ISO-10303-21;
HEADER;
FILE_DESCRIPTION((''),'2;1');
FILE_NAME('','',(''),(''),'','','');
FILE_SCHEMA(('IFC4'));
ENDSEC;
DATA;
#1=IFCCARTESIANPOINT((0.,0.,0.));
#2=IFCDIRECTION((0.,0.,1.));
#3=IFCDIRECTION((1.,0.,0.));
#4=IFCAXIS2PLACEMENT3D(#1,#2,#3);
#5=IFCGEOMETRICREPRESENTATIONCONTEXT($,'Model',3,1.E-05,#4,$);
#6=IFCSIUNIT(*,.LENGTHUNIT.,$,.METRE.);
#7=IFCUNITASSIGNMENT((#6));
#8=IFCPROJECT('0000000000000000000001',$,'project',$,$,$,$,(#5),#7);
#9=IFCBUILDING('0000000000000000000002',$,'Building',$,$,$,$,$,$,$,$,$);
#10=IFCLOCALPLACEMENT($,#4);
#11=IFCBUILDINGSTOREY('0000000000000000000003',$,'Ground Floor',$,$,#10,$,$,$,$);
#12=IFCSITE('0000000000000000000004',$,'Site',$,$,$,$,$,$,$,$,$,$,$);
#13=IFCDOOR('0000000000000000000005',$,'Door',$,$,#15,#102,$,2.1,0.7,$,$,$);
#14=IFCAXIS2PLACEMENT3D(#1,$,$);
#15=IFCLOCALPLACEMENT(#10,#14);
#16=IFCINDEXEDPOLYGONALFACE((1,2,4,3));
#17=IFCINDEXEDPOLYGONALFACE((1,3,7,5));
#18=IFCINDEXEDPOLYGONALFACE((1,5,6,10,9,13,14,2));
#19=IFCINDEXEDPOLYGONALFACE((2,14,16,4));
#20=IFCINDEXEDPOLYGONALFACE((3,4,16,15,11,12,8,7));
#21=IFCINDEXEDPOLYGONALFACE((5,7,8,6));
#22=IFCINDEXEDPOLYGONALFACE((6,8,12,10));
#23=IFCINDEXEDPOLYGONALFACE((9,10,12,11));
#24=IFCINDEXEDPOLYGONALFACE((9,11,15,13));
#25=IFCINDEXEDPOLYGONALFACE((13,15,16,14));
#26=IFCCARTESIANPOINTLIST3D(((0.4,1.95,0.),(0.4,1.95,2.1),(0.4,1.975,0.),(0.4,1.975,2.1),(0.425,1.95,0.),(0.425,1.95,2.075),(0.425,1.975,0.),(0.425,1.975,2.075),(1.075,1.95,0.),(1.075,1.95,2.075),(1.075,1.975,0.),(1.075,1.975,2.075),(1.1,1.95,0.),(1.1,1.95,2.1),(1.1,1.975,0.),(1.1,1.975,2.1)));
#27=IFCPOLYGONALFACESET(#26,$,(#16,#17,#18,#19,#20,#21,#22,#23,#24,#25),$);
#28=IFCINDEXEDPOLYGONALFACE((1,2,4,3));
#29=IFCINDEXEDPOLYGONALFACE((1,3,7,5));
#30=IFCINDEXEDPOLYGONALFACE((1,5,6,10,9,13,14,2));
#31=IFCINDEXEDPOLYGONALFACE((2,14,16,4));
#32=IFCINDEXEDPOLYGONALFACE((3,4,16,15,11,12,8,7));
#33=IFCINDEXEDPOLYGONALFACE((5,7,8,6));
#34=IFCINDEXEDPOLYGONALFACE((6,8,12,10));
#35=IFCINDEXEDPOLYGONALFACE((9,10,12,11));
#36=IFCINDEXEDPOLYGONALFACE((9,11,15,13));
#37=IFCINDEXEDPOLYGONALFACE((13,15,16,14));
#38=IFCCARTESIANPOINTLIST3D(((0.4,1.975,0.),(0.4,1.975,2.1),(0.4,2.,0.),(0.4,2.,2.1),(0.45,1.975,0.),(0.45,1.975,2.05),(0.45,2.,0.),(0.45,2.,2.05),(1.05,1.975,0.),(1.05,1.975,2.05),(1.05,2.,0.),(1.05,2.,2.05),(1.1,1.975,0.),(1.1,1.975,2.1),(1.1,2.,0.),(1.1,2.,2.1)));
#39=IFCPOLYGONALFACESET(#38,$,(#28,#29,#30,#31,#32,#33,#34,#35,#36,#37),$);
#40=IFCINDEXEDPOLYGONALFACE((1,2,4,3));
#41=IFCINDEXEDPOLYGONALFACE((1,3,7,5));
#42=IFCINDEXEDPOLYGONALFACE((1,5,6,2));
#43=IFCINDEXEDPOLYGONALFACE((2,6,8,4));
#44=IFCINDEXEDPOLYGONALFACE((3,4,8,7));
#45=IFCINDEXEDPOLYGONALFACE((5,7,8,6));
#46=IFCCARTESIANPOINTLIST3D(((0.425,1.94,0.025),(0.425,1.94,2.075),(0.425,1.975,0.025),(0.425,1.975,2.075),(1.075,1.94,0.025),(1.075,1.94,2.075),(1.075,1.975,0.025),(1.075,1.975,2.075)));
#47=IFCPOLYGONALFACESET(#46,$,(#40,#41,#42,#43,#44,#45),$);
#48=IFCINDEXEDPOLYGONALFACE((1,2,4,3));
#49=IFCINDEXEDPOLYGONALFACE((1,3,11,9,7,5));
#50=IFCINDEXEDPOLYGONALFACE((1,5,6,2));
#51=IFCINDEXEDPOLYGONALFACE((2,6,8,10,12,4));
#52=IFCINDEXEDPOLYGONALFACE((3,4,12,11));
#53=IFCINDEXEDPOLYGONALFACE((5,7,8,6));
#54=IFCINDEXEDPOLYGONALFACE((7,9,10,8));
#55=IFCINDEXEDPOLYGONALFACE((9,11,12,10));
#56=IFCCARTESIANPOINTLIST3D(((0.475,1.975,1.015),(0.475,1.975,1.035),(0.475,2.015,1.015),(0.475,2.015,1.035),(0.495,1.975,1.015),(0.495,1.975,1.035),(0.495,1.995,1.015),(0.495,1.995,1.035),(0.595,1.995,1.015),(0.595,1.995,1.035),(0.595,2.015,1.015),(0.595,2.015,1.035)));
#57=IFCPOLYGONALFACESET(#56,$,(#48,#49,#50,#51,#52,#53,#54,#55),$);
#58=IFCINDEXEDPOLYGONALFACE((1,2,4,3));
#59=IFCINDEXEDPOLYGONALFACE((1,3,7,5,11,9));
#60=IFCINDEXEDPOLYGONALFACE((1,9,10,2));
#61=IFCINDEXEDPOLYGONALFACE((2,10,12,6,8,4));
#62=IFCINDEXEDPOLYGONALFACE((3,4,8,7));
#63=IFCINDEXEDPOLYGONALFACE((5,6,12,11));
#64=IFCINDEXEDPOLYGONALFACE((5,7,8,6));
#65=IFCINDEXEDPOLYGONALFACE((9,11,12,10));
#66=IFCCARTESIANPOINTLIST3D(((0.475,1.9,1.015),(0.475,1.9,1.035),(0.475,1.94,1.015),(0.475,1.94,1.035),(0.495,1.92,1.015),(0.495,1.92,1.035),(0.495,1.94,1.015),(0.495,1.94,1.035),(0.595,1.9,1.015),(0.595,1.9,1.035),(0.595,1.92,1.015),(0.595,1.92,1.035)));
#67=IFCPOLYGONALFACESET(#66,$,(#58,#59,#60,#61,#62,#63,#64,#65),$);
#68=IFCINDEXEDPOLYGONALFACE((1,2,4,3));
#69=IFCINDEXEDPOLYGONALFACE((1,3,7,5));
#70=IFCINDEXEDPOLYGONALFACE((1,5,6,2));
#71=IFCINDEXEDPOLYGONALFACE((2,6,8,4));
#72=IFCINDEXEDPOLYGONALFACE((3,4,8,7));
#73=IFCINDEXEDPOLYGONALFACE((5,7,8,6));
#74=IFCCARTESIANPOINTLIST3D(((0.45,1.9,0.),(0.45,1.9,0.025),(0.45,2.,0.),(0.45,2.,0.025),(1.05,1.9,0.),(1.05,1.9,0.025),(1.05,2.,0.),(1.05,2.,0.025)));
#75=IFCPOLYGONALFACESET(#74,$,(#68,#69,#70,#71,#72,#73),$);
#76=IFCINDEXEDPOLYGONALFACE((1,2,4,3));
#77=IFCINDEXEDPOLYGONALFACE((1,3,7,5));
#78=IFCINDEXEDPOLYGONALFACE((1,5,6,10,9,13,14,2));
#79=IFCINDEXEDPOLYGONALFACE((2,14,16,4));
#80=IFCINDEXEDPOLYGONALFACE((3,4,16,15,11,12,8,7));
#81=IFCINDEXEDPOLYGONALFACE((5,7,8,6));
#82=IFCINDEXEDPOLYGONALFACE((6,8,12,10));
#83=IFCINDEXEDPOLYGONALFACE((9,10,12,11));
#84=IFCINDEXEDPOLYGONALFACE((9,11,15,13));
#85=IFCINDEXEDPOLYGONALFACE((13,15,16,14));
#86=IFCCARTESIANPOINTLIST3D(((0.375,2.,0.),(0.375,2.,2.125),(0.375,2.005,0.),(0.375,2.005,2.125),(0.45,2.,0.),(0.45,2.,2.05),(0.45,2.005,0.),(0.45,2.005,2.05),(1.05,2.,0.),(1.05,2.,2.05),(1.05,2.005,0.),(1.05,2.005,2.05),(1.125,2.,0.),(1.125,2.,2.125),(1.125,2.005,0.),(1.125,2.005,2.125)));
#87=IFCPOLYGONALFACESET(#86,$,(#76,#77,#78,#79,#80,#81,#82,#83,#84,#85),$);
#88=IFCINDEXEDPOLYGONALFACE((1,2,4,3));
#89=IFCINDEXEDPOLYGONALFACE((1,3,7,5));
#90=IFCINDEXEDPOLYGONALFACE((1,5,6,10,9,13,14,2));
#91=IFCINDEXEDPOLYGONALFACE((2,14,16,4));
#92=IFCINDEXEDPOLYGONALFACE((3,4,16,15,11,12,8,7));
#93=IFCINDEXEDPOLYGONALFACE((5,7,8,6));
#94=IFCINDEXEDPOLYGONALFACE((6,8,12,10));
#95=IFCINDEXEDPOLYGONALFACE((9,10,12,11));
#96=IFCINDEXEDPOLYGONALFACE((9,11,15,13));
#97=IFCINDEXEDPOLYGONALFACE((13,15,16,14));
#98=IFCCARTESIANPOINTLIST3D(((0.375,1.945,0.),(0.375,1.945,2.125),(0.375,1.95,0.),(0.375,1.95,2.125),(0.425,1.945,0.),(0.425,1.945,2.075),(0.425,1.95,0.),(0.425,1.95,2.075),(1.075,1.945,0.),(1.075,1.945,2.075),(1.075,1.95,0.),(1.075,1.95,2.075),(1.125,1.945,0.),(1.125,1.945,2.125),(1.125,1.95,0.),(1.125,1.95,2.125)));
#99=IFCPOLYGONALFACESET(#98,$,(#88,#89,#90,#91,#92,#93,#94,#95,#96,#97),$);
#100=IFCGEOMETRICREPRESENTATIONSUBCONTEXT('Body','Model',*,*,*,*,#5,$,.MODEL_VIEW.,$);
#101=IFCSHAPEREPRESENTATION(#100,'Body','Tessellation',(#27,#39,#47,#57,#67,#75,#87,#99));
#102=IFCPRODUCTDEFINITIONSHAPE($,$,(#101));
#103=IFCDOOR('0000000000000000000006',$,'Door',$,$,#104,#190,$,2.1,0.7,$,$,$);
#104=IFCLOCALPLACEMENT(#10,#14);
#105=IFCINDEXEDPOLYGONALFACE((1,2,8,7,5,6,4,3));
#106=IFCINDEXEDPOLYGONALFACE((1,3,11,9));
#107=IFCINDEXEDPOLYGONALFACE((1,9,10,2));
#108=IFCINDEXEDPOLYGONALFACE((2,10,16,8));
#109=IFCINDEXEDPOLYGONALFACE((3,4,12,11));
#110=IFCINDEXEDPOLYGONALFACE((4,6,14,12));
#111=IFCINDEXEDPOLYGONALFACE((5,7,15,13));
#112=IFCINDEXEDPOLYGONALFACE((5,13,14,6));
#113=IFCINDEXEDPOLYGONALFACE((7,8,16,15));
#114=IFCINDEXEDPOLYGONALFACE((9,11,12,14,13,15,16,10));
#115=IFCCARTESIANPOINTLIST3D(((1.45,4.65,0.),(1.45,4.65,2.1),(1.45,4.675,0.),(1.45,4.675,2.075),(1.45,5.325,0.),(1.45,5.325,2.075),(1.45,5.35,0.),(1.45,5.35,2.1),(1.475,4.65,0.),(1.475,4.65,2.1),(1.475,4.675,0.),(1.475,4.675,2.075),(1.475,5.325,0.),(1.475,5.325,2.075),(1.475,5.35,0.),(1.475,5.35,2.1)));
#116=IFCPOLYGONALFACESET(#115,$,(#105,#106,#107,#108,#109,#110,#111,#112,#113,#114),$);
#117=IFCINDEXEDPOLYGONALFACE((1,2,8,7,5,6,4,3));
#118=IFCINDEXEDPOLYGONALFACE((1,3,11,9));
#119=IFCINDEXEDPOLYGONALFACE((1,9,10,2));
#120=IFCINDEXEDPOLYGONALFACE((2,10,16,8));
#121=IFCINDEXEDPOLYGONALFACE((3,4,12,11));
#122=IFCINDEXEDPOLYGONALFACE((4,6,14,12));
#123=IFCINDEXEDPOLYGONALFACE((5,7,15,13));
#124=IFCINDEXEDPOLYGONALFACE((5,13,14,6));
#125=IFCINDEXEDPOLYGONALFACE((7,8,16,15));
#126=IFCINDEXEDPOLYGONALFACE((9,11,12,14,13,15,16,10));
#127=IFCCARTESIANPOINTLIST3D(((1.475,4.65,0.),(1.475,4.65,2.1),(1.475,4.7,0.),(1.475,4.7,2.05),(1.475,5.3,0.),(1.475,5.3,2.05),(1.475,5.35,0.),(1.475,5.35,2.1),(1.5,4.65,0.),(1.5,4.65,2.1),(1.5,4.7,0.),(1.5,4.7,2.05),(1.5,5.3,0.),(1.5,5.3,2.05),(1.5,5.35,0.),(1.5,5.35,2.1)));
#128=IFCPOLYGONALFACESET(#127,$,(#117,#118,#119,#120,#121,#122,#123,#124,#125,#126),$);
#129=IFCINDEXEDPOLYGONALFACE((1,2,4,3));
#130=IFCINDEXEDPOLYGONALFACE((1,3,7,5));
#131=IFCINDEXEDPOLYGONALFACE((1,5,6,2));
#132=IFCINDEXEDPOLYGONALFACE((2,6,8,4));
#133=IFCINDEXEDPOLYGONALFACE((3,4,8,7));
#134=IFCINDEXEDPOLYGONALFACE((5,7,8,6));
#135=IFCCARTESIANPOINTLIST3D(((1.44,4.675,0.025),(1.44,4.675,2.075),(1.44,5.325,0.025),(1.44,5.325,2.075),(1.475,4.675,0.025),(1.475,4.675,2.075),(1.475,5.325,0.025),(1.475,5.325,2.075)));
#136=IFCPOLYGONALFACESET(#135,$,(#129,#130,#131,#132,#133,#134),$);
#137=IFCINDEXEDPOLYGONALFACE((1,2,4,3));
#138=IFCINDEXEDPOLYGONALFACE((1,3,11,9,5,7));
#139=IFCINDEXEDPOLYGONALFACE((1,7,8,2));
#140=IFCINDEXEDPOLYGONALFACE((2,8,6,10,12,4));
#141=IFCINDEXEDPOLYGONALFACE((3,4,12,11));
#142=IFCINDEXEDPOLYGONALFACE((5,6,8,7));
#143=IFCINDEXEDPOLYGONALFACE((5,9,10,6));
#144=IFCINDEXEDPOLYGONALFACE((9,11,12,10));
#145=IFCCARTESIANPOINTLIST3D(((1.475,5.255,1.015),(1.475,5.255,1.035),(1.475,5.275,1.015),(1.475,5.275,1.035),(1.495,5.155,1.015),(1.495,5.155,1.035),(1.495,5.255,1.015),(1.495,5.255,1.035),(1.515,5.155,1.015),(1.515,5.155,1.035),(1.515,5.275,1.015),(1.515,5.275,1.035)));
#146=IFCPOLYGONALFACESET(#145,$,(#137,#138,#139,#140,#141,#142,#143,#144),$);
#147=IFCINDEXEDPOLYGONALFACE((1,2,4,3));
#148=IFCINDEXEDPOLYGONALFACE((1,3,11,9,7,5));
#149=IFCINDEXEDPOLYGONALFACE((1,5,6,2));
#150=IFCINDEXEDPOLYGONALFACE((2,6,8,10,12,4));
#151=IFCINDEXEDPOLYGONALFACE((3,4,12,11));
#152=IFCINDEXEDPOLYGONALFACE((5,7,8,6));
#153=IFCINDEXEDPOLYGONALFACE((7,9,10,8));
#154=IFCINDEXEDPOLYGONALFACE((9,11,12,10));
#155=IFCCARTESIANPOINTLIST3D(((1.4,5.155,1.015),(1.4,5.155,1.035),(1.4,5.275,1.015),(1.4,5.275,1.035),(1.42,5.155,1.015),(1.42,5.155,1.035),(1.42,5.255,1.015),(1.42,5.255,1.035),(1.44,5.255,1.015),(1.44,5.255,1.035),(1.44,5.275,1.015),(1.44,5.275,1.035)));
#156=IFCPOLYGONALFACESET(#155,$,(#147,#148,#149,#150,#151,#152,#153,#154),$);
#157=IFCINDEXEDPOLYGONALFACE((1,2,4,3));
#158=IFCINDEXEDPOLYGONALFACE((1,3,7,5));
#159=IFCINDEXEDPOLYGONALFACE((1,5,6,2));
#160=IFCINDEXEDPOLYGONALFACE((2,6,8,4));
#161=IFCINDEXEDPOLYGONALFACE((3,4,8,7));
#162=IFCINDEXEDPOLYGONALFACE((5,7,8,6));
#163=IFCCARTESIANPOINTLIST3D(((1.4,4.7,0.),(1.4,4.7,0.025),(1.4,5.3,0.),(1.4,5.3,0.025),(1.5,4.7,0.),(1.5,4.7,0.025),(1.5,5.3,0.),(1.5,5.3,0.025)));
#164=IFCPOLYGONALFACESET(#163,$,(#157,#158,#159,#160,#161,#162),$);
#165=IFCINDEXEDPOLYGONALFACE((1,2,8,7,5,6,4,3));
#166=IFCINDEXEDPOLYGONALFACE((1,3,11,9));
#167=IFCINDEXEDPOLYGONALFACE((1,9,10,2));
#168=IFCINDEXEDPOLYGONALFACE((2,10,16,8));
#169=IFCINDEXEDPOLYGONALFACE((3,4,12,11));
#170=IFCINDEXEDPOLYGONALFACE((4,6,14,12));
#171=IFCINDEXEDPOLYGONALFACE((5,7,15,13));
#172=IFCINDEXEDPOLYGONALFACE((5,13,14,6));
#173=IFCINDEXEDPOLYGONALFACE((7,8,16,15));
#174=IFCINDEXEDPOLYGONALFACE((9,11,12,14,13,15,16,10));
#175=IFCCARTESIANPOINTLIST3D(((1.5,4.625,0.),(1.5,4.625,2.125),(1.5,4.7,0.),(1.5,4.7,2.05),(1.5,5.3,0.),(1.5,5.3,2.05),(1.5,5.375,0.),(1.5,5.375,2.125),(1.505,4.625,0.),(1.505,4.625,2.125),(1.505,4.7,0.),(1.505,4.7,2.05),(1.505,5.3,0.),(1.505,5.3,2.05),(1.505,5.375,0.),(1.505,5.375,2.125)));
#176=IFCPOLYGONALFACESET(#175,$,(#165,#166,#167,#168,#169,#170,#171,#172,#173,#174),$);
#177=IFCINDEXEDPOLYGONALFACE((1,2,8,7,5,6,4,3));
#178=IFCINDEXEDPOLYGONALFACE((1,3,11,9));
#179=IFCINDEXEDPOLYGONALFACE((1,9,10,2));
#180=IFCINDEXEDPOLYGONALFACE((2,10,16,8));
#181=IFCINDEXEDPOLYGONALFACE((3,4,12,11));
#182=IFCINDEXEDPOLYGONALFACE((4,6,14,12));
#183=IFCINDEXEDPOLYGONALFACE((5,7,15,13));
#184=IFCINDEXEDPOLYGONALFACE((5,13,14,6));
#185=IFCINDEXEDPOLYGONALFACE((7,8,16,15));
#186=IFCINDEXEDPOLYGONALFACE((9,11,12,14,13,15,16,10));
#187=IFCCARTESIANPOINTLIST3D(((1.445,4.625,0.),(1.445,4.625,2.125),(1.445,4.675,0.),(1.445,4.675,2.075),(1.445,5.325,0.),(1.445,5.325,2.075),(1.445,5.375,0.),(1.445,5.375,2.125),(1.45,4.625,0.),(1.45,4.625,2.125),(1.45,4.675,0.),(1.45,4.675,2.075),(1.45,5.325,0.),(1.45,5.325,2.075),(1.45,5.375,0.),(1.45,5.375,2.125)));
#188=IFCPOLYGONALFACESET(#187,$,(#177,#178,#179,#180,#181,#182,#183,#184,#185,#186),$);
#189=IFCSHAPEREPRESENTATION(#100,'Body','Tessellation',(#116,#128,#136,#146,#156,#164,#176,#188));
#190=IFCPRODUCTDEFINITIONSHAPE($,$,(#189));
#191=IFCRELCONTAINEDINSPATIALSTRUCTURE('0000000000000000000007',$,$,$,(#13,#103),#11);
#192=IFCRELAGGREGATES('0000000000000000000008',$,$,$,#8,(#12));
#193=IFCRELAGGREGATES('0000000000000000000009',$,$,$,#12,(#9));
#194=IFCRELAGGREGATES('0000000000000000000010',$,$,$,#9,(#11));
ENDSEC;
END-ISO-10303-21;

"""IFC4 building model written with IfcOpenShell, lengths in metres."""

from ifc_helpers import new_model, si_unit, frame, origin_with_axes, place, context, subcontext, project, spatial, line, indexed_curve, outline, extrude, element, save


model = new_model("IFC4")

# Units and contexts
model_context = context("Model", 3, precision=1e-05, world=origin_with_axes())
body_context = subcontext(model_context, "Body", "Model", "MODEL_VIEW")
ifc_project = project(units=[si_unit("LENGTHUNIT", "METRE")], contexts=[model_context])

# Site, building, storey
site = spatial("IfcSite", under=ifc_project, Name="Site")
building = spatial("IfcBuilding", under=site, Name="Building")
storey_placement = place(None, origin_with_axes())
storey = spatial("IfcBuildingStorey", under=building, at=storey_placement, Name="Ground Floor")

# Doors
door_1_placement = place(storey_placement, frame((1.1, 2.0, 0.0), z_axis=(0.0, 0.0, 1.0), x_axis=(-1.0, 0.0, 0.0)))
element("IfcDoor", 1, at=door_1_placement, inside=storey, Name="Door", OverallHeight=2.1, OverallWidth=0.7, context=body_context, shape_type="SweptSolid", body=[
    extrude(outline(indexed_curve([(0.0, 0.0), (0.0, 2.1), (0.7, 2.1), (0.7, 0.0), (0.675, 0.0), (0.675, 2.075), (0.025, 2.075), (0.025, 0.0)], segments=[line(1, 2, 3, 4, 5, 6, 7, 8, 1)])), frame((0.0, 0.025, 0.0), z_axis=(0.0, -1.0, 0.0), x_axis=(1.0, 0.0, 0.0)), (0.0, 0.0, -1.0), 0.025),
    extrude(outline(indexed_curve([(0.0, 0.0), (0.0, 2.1), (0.7, 2.1), (0.7, 0.0), (0.65, 0.0), (0.65, 2.05), (0.05, 2.05), (0.05, 0.0)], segments=[line(1, 2, 3, 4, 5, 6, 7, 8, 1)])), frame((0.0, 0.0, 0.0), z_axis=(0.0, -1.0, 0.0), x_axis=(1.0, 0.0, 0.0)), (0.0, 0.0, -1.0), 0.025),
    extrude(outline(indexed_curve([(0.0, 0.0), (0.65, 0.0), (0.65, 0.035), (0.0, 0.035)], segments=[line(1, 2, 3, 4, 1)])), frame((0.025, 0.025, 0.025), z_axis=(0.0, 0.0, 1.0), x_axis=(1.0, 0.0, 0.0)), (0.0, 0.0, 1.0), 2.05),
    extrude(outline(indexed_curve([(0.0, 0.0), (0.0, -0.04), (-0.12, -0.04), (-0.12, -0.02), (-0.02, -0.02), (-0.02, 0.0)], segments=[line(1, 2, 3, 4, 5, 6, 1)])), frame((0.625, 0.025, 1.015), z_axis=(0.0, 0.0, 1.0), x_axis=(1.0, 0.0, 0.0)), (0.0, 0.0, 1.0), 0.02),
    extrude(outline(indexed_curve([(0.0, 0.0), (0.0, 0.04), (-0.12, 0.04), (-0.12, 0.02), (-0.02, 0.02), (-0.02, 0.0)], segments=[line(1, 2, 3, 4, 5, 6, 1)])), frame((0.625, 0.06, 1.015), z_axis=(0.0, 0.0, 1.0), x_axis=(1.0, 0.0, 0.0)), (0.0, 0.0, 1.0), 0.02),
    extrude(outline(indexed_curve([(0.0, 0.0), (0.6, 0.0), (0.6, 0.1), (0.0, 0.1)], segments=[line(1, 2, 3, 4, 1)])), frame((0.05, 0.0, 0.0), z_axis=(0.0, 0.0, 1.0), x_axis=(1.0, 0.0, 0.0)), (0.0, 0.0, 1.0), 0.025),
    extrude(outline(indexed_curve([(0.0, 0.0), (0.0, 2.125), (0.75, 2.125), (0.75, 0.0), (0.675, 0.0), (0.675, 2.05), (0.075, 2.05), (0.075, 0.0)], segments=[line(1, 2, 3, 4, 5, 6, 7, 8, 1)])), frame((-0.025, -0.005, 0.0), z_axis=(0.0, -1.0, 0.0), x_axis=(1.0, 0.0, 0.0)), (0.0, 0.0, -1.0), 0.005),
    extrude(outline(indexed_curve([(0.0, 0.0), (0.0, 2.125), (0.75, 2.125), (0.75, 0.0), (0.7, 0.0), (0.7, 2.075), (0.05, 2.075), (0.05, 0.0)], segments=[line(1, 2, 3, 4, 5, 6, 7, 8, 1)])), frame((-0.025, 0.05, 0.0), z_axis=(0.0, -1.0, 0.0), x_axis=(1.0, 0.0, 0.0)), (0.0, 0.0, -1.0), 0.005),
])
door_2_placement = place(storey_placement, frame((1.5, 4.65, 0.0), z_axis=(0.0, 0.0, 1.0), x_axis=(0.0, 1.0, 0.0)))
element("IfcDoor", 2, at=door_2_placement, inside=storey, Name="Door", OverallHeight=2.1, OverallWidth=0.7, context=body_context, shape_type="SweptSolid", body=[
    extrude(outline(indexed_curve([(0.0, 0.0), (0.0, 2.1), (0.7, 2.1), (0.7, 0.0), (0.675, 0.0), (0.675, 2.075), (0.025, 2.075), (0.025, 0.0)], segments=[line(1, 2, 3, 4, 5, 6, 7, 8, 1)])), frame((0.0, 0.025, 0.0), z_axis=(0.0, -1.0, 0.0), x_axis=(1.0, 0.0, 0.0)), (0.0, 0.0, -1.0), 0.025),
    extrude(outline(indexed_curve([(0.0, 0.0), (0.0, 2.1), (0.7, 2.1), (0.7, 0.0), (0.65, 0.0), (0.65, 2.05), (0.05, 2.05), (0.05, 0.0)], segments=[line(1, 2, 3, 4, 5, 6, 7, 8, 1)])), frame((0.0, 0.0, 0.0), z_axis=(0.0, -1.0, 0.0), x_axis=(1.0, 0.0, 0.0)), (0.0, 0.0, -1.0), 0.025),
    extrude(outline(indexed_curve([(0.0, 0.0), (0.65, 0.0), (0.65, 0.035), (0.0, 0.035)], segments=[line(1, 2, 3, 4, 1)])), frame((0.025, 0.025, 0.025), z_axis=(0.0, 0.0, 1.0), x_axis=(1.0, 0.0, 0.0)), (0.0, 0.0, 1.0), 2.05),
    extrude(outline(indexed_curve([(0.0, 0.0), (0.0, -0.04), (-0.12, -0.04), (-0.12, -0.02), (-0.02, -0.02), (-0.02, 0.0)], segments=[line(1, 2, 3, 4, 5, 6, 1)])), frame((0.625, 0.025, 1.015), z_axis=(0.0, 0.0, 1.0), x_axis=(1.0, 0.0, 0.0)), (0.0, 0.0, 1.0), 0.02),
    extrude(outline(indexed_curve([(0.0, 0.0), (0.0, 0.04), (-0.12, 0.04), (-0.12, 0.02), (-0.02, 0.02), (-0.02, 0.0)], segments=[line(1, 2, 3, 4, 5, 6, 1)])), frame((0.625, 0.06, 1.015), z_axis=(0.0, 0.0, 1.0), x_axis=(1.0, 0.0, 0.0)), (0.0, 0.0, 1.0), 0.02),
    extrude(outline(indexed_curve([(0.0, 0.0), (0.6, 0.0), (0.6, 0.1), (0.0, 0.1)], segments=[line(1, 2, 3, 4, 1)])), frame((0.05, 0.0, 0.0), z_axis=(0.0, 0.0, 1.0), x_axis=(1.0, 0.0, 0.0)), (0.0, 0.0, 1.0), 0.025),
    extrude(outline(indexed_curve([(0.0, 0.0), (0.0, 2.125), (0.75, 2.125), (0.75, 0.0), (0.675, 0.0), (0.675, 2.05), (0.075, 2.05), (0.075, 0.0)], segments=[line(1, 2, 3, 4, 5, 6, 7, 8, 1)])), frame((-0.025, -0.005, 0.0), z_axis=(0.0, -1.0, 0.0), x_axis=(1.0, 0.0, 0.0)), (0.0, 0.0, -1.0), 0.005),
    extrude(outline(indexed_curve([(0.0, 0.0), (0.0, 2.125), (0.75, 2.125), (0.75, 0.0), (0.7, 0.0), (0.7, 2.075), (0.05, 2.075), (0.05, 0.0)], segments=[line(1, 2, 3, 4, 5, 6, 7, 8, 1)])), frame((-0.025, 0.05, 0.0), z_axis=(0.0, -1.0, 0.0), x_axis=(1.0, 0.0, 0.0)), (0.0, 0.0, -1.0), 0.005),
])

save(model, "model.ifc")
